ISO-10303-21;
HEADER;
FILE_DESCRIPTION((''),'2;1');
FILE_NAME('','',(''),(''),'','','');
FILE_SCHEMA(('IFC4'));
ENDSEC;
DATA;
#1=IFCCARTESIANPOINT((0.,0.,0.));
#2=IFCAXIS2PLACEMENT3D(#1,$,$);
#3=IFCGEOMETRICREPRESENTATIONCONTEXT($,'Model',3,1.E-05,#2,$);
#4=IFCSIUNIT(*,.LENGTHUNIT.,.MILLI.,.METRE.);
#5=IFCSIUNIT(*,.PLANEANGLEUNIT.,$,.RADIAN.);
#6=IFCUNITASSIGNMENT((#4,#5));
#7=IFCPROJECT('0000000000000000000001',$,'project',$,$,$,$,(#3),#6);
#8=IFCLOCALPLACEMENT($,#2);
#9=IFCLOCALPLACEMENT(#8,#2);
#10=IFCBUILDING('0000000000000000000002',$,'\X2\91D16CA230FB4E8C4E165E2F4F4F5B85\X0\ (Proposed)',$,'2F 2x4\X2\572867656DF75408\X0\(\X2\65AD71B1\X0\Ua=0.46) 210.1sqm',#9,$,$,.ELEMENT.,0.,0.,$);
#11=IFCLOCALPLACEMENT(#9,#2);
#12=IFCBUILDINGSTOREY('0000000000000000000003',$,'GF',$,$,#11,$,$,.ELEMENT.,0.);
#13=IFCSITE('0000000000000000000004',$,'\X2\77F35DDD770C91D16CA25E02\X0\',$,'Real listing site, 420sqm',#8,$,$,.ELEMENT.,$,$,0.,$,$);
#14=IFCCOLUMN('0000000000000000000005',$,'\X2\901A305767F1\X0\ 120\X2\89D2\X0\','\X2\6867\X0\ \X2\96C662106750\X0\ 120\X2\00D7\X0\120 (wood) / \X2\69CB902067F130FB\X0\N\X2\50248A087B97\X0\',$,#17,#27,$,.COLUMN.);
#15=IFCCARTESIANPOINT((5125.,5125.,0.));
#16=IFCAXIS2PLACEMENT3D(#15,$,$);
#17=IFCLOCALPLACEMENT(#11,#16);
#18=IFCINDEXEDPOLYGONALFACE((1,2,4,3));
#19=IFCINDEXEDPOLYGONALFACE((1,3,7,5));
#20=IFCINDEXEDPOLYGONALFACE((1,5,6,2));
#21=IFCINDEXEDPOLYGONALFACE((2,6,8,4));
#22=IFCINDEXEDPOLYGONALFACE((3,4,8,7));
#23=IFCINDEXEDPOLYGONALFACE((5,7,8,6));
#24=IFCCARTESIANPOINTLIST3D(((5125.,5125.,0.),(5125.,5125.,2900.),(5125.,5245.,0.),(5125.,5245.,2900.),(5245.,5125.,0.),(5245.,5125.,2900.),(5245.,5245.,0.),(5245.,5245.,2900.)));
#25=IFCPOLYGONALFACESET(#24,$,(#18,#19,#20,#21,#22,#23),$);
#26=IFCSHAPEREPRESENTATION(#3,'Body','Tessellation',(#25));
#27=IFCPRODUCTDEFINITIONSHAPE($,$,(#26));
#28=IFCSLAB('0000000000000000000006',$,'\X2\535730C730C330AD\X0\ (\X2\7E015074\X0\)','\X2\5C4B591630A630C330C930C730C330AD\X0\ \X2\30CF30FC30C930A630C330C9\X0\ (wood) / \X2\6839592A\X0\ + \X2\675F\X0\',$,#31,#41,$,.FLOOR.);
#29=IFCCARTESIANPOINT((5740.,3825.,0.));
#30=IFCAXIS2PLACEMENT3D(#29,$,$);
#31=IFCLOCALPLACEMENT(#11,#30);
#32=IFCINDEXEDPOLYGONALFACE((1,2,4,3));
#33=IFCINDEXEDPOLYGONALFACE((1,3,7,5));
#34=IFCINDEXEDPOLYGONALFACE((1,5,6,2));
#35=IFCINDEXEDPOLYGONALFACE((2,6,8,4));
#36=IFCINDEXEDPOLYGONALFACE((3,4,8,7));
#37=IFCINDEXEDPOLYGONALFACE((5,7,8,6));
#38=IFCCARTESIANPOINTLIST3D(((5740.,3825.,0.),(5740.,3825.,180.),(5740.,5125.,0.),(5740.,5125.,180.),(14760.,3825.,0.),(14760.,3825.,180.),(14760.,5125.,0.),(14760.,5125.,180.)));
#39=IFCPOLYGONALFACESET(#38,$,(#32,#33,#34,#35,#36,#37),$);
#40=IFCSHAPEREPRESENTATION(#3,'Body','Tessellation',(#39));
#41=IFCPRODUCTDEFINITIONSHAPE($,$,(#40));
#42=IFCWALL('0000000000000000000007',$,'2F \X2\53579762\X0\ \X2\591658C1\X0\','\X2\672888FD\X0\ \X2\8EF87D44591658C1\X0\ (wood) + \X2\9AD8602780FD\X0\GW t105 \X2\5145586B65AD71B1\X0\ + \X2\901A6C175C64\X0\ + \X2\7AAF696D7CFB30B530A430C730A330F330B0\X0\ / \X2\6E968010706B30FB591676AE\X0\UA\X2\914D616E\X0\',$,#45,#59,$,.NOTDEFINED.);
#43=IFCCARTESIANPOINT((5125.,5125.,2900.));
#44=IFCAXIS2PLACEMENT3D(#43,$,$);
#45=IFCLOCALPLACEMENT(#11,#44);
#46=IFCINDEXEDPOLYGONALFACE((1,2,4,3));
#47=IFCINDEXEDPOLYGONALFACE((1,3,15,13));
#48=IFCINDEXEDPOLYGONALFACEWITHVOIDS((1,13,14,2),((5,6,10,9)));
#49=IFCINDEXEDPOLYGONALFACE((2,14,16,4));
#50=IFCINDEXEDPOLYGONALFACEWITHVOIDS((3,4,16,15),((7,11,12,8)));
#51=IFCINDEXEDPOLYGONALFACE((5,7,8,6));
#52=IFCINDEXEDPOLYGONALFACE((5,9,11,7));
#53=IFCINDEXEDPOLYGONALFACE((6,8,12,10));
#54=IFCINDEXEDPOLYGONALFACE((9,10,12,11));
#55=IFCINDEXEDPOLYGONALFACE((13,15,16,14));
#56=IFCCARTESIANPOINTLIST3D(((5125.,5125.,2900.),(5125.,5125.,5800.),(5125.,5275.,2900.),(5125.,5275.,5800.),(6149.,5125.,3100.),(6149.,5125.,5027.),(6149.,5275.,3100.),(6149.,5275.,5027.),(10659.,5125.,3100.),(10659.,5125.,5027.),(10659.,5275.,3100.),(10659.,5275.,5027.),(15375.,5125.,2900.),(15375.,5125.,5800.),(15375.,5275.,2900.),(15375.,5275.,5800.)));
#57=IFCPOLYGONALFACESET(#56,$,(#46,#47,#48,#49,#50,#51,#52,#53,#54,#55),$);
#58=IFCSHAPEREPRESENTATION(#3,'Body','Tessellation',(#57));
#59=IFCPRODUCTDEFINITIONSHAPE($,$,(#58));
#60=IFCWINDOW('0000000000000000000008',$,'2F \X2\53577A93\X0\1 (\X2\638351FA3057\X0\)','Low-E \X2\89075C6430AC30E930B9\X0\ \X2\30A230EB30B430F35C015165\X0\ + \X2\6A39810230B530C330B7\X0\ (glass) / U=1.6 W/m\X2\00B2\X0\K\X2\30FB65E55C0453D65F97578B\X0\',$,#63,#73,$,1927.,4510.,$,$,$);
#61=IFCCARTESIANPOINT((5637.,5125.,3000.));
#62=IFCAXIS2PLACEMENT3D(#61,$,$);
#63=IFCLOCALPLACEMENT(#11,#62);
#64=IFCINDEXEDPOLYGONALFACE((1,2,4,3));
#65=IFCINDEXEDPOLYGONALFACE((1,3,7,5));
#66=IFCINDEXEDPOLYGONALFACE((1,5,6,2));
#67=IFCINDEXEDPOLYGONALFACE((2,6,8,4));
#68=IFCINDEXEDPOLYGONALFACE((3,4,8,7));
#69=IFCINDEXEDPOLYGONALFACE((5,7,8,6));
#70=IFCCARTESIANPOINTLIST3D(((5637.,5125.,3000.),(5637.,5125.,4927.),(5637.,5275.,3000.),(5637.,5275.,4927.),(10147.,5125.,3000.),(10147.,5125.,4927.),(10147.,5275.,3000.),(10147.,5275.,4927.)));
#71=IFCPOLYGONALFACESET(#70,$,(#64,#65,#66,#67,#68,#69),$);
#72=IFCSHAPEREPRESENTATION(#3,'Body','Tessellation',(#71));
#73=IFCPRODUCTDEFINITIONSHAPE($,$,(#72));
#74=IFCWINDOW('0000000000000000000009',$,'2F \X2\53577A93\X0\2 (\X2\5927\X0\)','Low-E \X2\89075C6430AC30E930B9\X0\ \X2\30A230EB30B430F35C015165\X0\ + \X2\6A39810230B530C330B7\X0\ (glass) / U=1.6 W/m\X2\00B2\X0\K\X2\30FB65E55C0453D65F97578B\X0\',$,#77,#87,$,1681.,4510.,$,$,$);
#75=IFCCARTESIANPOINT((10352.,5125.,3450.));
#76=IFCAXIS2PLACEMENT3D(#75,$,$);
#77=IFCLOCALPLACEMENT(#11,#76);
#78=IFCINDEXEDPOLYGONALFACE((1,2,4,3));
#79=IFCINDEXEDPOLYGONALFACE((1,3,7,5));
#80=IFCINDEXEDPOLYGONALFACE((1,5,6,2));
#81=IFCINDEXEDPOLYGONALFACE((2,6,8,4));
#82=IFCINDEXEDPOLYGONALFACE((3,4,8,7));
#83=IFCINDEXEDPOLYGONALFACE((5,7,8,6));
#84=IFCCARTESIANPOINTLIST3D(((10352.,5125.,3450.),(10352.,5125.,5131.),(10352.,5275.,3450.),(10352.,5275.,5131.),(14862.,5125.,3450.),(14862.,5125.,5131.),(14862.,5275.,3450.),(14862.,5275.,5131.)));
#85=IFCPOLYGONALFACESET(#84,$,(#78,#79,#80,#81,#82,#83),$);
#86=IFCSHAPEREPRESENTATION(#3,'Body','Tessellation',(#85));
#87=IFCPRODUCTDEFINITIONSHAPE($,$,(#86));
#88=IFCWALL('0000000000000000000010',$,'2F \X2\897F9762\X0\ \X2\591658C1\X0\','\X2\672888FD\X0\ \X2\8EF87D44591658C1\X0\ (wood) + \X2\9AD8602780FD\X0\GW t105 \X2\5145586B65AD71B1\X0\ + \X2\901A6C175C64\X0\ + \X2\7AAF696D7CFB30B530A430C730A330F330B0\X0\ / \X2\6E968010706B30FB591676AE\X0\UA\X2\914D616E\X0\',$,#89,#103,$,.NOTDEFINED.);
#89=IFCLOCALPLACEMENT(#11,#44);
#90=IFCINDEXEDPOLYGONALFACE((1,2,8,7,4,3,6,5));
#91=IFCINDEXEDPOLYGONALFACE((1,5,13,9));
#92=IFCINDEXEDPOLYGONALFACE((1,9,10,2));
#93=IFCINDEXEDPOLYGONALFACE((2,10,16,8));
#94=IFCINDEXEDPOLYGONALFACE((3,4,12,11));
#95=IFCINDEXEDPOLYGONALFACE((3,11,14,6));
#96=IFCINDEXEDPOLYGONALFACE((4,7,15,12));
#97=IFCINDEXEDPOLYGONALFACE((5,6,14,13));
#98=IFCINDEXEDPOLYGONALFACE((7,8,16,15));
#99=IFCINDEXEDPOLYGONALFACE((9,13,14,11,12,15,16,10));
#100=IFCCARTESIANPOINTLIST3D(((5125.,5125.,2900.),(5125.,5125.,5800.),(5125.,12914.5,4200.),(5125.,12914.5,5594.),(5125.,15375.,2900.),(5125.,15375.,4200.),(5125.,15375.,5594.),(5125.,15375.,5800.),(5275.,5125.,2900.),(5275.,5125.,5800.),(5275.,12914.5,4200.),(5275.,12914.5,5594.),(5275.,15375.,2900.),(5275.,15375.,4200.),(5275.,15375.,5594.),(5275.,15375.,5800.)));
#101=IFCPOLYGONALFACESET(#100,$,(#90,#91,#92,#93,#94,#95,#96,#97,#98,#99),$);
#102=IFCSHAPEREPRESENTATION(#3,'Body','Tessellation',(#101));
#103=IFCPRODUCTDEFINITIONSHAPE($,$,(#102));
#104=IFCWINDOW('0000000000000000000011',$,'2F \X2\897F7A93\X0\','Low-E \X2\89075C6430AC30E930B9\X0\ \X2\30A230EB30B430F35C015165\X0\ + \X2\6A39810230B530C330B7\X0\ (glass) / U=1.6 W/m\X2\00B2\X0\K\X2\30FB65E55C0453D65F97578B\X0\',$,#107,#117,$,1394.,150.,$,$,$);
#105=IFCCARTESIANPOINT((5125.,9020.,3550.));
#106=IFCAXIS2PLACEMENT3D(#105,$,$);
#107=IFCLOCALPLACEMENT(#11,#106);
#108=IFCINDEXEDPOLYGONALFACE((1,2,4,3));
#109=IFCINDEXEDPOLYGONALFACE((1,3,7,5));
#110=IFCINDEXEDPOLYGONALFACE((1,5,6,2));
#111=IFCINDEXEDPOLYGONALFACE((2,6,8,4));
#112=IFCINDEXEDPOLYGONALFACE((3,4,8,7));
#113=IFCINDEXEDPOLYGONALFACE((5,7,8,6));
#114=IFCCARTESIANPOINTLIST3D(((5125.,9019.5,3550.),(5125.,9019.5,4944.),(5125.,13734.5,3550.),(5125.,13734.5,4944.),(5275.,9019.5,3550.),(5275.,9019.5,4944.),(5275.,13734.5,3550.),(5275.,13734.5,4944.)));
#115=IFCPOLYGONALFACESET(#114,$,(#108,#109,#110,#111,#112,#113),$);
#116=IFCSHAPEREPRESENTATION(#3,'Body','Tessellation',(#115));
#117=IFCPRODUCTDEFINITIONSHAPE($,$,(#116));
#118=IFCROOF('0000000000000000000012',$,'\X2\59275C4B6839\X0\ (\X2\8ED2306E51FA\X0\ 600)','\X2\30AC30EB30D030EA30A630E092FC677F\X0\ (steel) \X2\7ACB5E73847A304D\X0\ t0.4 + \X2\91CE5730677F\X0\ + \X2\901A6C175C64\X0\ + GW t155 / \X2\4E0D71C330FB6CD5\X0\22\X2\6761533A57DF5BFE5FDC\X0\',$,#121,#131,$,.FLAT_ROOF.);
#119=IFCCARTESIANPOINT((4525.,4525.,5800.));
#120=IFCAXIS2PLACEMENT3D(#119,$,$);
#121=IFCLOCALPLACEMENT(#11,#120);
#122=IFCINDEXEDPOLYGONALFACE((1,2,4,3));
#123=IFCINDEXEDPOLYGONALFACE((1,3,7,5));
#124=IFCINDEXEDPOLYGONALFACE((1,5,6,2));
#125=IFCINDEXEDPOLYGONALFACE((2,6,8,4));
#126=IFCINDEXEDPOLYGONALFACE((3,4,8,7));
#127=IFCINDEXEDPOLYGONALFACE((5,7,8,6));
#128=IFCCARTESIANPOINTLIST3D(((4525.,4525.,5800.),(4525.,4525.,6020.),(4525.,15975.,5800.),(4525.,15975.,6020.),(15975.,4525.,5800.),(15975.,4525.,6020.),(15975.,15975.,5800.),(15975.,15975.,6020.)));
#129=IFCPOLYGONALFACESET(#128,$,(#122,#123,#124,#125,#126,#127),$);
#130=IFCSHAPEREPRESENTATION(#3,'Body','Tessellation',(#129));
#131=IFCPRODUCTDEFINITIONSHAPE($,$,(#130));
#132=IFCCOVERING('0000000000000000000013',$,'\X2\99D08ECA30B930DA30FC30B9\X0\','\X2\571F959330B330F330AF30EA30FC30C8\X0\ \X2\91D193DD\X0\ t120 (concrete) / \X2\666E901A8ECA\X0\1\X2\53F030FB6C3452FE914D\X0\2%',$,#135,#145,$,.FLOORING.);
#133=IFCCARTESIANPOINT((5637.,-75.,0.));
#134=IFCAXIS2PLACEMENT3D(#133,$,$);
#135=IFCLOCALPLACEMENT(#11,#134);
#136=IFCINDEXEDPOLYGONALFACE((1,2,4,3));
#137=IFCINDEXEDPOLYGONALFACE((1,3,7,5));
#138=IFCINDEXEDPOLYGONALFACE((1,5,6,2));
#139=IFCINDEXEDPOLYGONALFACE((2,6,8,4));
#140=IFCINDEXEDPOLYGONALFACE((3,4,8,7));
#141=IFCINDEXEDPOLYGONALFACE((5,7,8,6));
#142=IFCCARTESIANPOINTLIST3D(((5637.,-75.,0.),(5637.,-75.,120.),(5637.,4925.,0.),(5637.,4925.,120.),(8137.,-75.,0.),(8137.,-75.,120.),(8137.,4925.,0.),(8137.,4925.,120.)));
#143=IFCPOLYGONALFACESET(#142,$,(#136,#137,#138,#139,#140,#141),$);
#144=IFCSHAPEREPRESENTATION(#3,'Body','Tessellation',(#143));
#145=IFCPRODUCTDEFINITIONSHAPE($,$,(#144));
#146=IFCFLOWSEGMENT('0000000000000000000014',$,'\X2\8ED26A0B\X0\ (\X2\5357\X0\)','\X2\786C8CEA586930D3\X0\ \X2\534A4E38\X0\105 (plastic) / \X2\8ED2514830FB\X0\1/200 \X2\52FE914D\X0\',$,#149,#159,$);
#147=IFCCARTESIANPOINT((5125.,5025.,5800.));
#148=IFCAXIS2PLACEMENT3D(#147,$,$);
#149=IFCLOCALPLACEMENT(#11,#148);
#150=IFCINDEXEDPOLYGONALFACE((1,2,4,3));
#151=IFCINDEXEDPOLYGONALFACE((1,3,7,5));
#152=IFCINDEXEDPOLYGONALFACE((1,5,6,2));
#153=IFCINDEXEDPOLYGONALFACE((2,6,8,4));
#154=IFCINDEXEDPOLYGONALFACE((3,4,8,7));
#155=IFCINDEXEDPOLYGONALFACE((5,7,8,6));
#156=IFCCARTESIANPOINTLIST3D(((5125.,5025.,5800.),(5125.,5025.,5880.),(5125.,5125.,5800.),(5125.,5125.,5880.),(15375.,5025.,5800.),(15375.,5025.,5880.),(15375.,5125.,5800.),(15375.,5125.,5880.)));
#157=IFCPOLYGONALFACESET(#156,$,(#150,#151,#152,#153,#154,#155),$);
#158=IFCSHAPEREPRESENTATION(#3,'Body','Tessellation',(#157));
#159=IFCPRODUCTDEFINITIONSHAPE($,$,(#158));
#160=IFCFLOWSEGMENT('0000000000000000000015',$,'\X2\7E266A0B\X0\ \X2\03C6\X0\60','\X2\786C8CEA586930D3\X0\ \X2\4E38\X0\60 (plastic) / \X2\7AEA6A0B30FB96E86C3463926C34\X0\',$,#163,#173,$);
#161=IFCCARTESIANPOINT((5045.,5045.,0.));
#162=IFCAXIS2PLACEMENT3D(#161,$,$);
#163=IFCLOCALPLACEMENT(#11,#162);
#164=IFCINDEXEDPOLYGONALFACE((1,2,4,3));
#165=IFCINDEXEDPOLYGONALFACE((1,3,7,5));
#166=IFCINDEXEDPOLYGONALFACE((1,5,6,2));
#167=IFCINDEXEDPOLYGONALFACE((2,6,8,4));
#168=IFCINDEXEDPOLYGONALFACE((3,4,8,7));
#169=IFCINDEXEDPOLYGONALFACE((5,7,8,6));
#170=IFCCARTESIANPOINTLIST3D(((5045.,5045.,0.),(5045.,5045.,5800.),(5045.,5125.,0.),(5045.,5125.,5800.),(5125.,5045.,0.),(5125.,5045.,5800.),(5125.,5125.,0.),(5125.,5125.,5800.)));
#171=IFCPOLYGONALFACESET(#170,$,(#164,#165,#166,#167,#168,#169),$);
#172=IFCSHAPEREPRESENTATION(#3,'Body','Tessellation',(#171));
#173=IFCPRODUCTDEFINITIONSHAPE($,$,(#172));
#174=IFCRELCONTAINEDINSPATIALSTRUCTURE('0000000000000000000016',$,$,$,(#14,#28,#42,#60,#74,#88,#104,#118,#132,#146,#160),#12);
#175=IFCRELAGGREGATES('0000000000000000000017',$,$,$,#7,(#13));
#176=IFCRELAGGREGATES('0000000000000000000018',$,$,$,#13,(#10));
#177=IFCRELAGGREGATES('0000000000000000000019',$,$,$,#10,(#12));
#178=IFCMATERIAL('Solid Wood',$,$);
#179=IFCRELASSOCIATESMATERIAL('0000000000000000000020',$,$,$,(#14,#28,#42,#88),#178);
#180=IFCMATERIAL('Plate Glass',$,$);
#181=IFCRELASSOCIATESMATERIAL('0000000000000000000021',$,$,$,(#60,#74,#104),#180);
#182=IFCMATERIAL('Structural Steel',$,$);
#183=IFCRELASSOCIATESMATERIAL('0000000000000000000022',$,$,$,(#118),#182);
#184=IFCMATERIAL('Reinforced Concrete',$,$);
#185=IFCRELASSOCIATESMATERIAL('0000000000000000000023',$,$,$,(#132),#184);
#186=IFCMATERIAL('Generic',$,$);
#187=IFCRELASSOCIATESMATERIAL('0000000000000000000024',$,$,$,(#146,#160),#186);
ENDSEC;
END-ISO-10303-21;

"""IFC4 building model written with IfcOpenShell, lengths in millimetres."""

from ifc_helpers import new_model, si_unit, frame, frame_2d, origin, place, context, project, spatial, rectangle, extrude, material, element, fill, save


model = new_model("IFC4")

# Units and contexts
model_context = context("Model", 3, precision=1e-05, world=origin())
ifc_project = project(units=[si_unit("LENGTHUNIT", "METRE", prefix="MILLI"), si_unit("PLANEANGLEUNIT", "RADIAN")], contexts=[model_context])

# Site, building, storey
site_placement = place(None, origin())
site = spatial("IfcSite", under=ifc_project, at=site_placement, Name="石川県金沢市", ObjectType="Real listing site, 420sqm", CompositionType="ELEMENT", RefElevation=0.0)
building_placement = place(site_placement, origin())
building = spatial("IfcBuilding", under=site, at=building_placement, Name="金沢・二世帯住宅 (Proposed)", ObjectType="2F 2x4在来混合(断熱Ua=0.46) 210.1sqm", CompositionType="ELEMENT", ElevationOfRefHeight=0.0, ElevationOfTerrain=0.0)
storey_placement = place(building_placement, origin())
storey = spatial("IfcBuildingStorey", under=building, at=storey_placement, Name="GF", CompositionType="ELEMENT", Elevation=0.0)

# Column
ifc_material_1 = material(Name="Solid Wood")
column_placement = place(storey_placement, frame((5125.0, 5125.0, 0.0)))
element("IfcColumn", 1, at=column_placement, inside=storey, material=ifc_material_1, Name="通し柱 120角", Description="桧 集成材 120×120 (wood) / 構造柱・N値計算", PredefinedType="COLUMN", context=model_context, shape_type="SweptSolid", body=[
    extrude(rectangle(XDim=120.0, YDim=120.0, at=frame_2d((60.0, 60.0))), frame((5125.0, 5125.0, 0.0)), (0.0, 0.0, 1.0), 2900.0),
])

# Slab
ifc_material_2 = material(Name="Reinforced Concrete")
slab_1_placement = place(storey_placement, frame((5740.0, 3825.0, 0.0)))
element("IfcSlab", 2, at=slab_1_placement, inside=storey, material=ifc_material_1, Name="南デッキ (縁側)", Description="屋外ウッドデッキ ハードウッド (wood) / 根太 + 束", PredefinedType="FLOOR", context=model_context, shape_type="SweptSolid", body=[
    extrude(rectangle(XDim=9020.0, YDim=1300.0, at=frame_2d((4510.0, 650.0))), frame((5740.0, 3825.0, 0.0)), (0.0, 0.0, 1.0), 180.0),
])

# Shared definitions
ifc_material_3 = material(Name="Plate Glass")

# Wall, openings, windows
wall_1_placement = place(storey_placement, frame((5125.0, 5125.0, 2900.0)))
wall_1 = element("IfcWall", 3, at=wall_1_placement, inside=storey, material=ifc_material_1, Name="2F 南面 外壁", Description="木製 軸組外壁 (wood) + 高性能GW t105 充填断熱 + 通気層 + 窯業系サイディング / 準耐火・外皮UA配慮", PredefinedType="NOTDEFINED", context=model_context, shape_type="SweptSolid", body=[
    extrude(rectangle(XDim=10250.0, YDim=150.0, at=frame_2d((5125.0, 75.0))), frame((5125.0, 5125.0, 2900.0)), (0.0, 0.0, 1.0), 2900.0),
])
opening_1_placement = place(storey_placement, frame((5637.0, 5125.0, 3000.0)))
opening_1 = element("IfcOpeningElement", 4, at=opening_1_placement, cuts=wall_1, PredefinedType="NOTDEFINED", context=model_context, shape_type="SweptSolid", body=[
    extrude(rectangle(XDim=4510.0, YDim=150.0, at=frame_2d((2255.0, 75.0))), frame((5637.0, 5125.0, 3000.0)), (0.0, 0.0, 1.0), 1927.0),
])
opening_2_placement = place(storey_placement, frame((10352.0, 5125.0, 3450.0)))
opening_2 = element("IfcOpeningElement", 5, at=opening_2_placement, cuts=wall_1, PredefinedType="NOTDEFINED", context=model_context, shape_type="SweptSolid", body=[
    extrude(rectangle(XDim=4510.0, YDim=150.0, at=frame_2d((2255.0, 75.0))), frame((10352.0, 5125.0, 3450.0)), (0.0, 0.0, 1.0), 1681.0),
])
window_1_placement = place(storey_placement, frame((5637.0, 5125.0, 3000.0)))
window_1 = element("IfcWindow", 6, at=window_1_placement, inside=storey, material=ifc_material_3, Name="2F 南窓1 (掃出し)", Description="Low-E 複層ガラス アルゴン封入 + 樹脂サッシ (glass) / U=1.6 W/m²K・日射取得型", OverallHeight=1927.0, OverallWidth=4510.0, context=model_context, shape_type="SweptSolid", body=[
    extrude(rectangle(XDim=4510.0, YDim=150.0, at=frame_2d((2255.0, 75.0))), frame((5637.0, 5125.0, 3000.0)), (0.0, 0.0, 1.0), 1927.0),
])
fill(opening_1, window_1)
window_2_placement = place(storey_placement, frame((10352.0, 5125.0, 3450.0)))
window_2 = element("IfcWindow", 7, at=window_2_placement, inside=storey, material=ifc_material_3, Name="2F 南窓2 (大)", Description="Low-E 複層ガラス アルゴン封入 + 樹脂サッシ (glass) / U=1.6 W/m²K・日射取得型", OverallHeight=1681.0, OverallWidth=4510.0, context=model_context, shape_type="SweptSolid", body=[
    extrude(rectangle(XDim=4510.0, YDim=150.0, at=frame_2d((2255.0, 75.0))), frame((10352.0, 5125.0, 3450.0)), (0.0, 0.0, 1.0), 1681.0),
])
fill(opening_2, window_2)

# Wall, opening, window
wall_2_placement = place(storey_placement, frame((5125.0, 5125.0, 2900.0)))
wall_2 = element("IfcWall", 8, at=wall_2_placement, inside=storey, material=ifc_material_1, Name="2F 西面 外壁", Description="木製 軸組外壁 (wood) + 高性能GW t105 充填断熱 + 通気層 + 窯業系サイディング / 準耐火・外皮UA配慮", PredefinedType="NOTDEFINED", context=model_context, shape_type="SweptSolid", body=[
    extrude(rectangle(XDim=150.0, YDim=10250.0, at=frame_2d((75.0, 5125.0))), frame((5125.0, 5125.0, 2900.0)), (0.0, 0.0, 1.0), 2900.0),
])
opening_3_placement = place(storey_placement, frame((5125.0, 9020.0, 3550.0)))
opening_3 = element("IfcOpeningElement", 9, at=opening_3_placement, cuts=wall_2, PredefinedType="NOTDEFINED", context=model_context, shape_type="SweptSolid", body=[
    extrude(rectangle(XDim=150.0, YDim=4715.0, at=frame_2d((75.0, 2357.0))), frame((5125.0, 9020.0, 3550.0)), (0.0, 0.0, 1.0), 1394.0),
])
window_3_placement = place(storey_placement, frame((5125.0, 9020.0, 3550.0)))
window_3 = element("IfcWindow", 10, at=window_3_placement, inside=storey, material=ifc_material_3, Name="2F 西窓", Description="Low-E 複層ガラス アルゴン封入 + 樹脂サッシ (glass) / U=1.6 W/m²K・日射取得型", OverallHeight=1394.0, OverallWidth=150.0, context=model_context, shape_type="SweptSolid", body=[
    extrude(rectangle(XDim=150.0, YDim=4715.0, at=frame_2d((75.0, 2357.0))), frame((5125.0, 9020.0, 3550.0)), (0.0, 0.0, 1.0), 1394.0),
])
fill(opening_3, window_3)

# Roof
ifc_material_4 = material(Name="Structural Steel")
roof_placement = place(storey_placement, frame((4525.0, 4525.0, 5800.0)))
element("IfcRoof", 11, at=roof_placement, inside=storey, material=ifc_material_4, Name="大屋根 (軒の出 600)", Description="ガルバリウム鋼板 (steel) 立平葺き t0.4 + 野地板 + 通気層 + GW t155 / 不燃・法22条区域対応", PredefinedType="FLAT_ROOF", context=model_context, shape_type="SweptSolid", body=[
    extrude(rectangle(XDim=11450.0, YDim=11450.0, at=frame_2d((5725.0, 5725.0))), frame((4525.0, 4525.0, 5800.0)), (0.0, 0.0, 1.0), 220.0),
])

# Covering
covering_placement = place(storey_placement, frame((5637.0, -75.0, 0.0)))
element("IfcCovering", 12, at=covering_placement, inside=storey, material=ifc_material_2, Name="駐車スペース", Description="土間コンクリート 金鏝 t120 (concrete) / 普通車1台・水勾配2%", PredefinedType="FLOORING", context=model_context, shape_type="SweptSolid", body=[
    extrude(rectangle(XDim=2500.0, YDim=5000.0, at=frame_2d((1250.0, 2500.0))), frame((5637.0, -75.0, 0.0)), (0.0, 0.0, 1.0), 120.0),
])

# Flow segments
ifc_material_5 = material(Name="Generic")
flow_segment_1_placement = place(storey_placement, frame((5125.0, 5025.0, 5800.0)))
element("IfcFlowSegment", 13, at=flow_segment_1_placement, inside=storey, material=ifc_material_5, Name="軒樋 (南)", Description="硬質塩ビ 半丸105 (plastic) / 軒先・1/200 勾配", context=model_context, shape_type="SweptSolid", body=[
    extrude(rectangle(XDim=10250.0, YDim=100.0, at=frame_2d((5125.0, 50.0))), frame((5125.0, 5025.0, 5800.0)), (0.0, 0.0, 1.0), 80.0),
])
flow_segment_2_placement = place(storey_placement, frame((5045.0, 5045.0, 0.0)))
element("IfcFlowSegment", 14, at=flow_segment_2_placement, inside=storey, material=ifc_material_5, Name="縦樋 φ60", Description="硬質塩ビ 丸60 (plastic) / 竪樋・雨水排水", context=model_context, shape_type="SweptSolid", body=[
    extrude(rectangle(XDim=80.0, YDim=80.0, at=frame_2d((40.0, 40.0))), frame((5045.0, 5045.0, 0.0)), (0.0, 0.0, 1.0), 5800.0),
])

save(model, "model.ifc")
